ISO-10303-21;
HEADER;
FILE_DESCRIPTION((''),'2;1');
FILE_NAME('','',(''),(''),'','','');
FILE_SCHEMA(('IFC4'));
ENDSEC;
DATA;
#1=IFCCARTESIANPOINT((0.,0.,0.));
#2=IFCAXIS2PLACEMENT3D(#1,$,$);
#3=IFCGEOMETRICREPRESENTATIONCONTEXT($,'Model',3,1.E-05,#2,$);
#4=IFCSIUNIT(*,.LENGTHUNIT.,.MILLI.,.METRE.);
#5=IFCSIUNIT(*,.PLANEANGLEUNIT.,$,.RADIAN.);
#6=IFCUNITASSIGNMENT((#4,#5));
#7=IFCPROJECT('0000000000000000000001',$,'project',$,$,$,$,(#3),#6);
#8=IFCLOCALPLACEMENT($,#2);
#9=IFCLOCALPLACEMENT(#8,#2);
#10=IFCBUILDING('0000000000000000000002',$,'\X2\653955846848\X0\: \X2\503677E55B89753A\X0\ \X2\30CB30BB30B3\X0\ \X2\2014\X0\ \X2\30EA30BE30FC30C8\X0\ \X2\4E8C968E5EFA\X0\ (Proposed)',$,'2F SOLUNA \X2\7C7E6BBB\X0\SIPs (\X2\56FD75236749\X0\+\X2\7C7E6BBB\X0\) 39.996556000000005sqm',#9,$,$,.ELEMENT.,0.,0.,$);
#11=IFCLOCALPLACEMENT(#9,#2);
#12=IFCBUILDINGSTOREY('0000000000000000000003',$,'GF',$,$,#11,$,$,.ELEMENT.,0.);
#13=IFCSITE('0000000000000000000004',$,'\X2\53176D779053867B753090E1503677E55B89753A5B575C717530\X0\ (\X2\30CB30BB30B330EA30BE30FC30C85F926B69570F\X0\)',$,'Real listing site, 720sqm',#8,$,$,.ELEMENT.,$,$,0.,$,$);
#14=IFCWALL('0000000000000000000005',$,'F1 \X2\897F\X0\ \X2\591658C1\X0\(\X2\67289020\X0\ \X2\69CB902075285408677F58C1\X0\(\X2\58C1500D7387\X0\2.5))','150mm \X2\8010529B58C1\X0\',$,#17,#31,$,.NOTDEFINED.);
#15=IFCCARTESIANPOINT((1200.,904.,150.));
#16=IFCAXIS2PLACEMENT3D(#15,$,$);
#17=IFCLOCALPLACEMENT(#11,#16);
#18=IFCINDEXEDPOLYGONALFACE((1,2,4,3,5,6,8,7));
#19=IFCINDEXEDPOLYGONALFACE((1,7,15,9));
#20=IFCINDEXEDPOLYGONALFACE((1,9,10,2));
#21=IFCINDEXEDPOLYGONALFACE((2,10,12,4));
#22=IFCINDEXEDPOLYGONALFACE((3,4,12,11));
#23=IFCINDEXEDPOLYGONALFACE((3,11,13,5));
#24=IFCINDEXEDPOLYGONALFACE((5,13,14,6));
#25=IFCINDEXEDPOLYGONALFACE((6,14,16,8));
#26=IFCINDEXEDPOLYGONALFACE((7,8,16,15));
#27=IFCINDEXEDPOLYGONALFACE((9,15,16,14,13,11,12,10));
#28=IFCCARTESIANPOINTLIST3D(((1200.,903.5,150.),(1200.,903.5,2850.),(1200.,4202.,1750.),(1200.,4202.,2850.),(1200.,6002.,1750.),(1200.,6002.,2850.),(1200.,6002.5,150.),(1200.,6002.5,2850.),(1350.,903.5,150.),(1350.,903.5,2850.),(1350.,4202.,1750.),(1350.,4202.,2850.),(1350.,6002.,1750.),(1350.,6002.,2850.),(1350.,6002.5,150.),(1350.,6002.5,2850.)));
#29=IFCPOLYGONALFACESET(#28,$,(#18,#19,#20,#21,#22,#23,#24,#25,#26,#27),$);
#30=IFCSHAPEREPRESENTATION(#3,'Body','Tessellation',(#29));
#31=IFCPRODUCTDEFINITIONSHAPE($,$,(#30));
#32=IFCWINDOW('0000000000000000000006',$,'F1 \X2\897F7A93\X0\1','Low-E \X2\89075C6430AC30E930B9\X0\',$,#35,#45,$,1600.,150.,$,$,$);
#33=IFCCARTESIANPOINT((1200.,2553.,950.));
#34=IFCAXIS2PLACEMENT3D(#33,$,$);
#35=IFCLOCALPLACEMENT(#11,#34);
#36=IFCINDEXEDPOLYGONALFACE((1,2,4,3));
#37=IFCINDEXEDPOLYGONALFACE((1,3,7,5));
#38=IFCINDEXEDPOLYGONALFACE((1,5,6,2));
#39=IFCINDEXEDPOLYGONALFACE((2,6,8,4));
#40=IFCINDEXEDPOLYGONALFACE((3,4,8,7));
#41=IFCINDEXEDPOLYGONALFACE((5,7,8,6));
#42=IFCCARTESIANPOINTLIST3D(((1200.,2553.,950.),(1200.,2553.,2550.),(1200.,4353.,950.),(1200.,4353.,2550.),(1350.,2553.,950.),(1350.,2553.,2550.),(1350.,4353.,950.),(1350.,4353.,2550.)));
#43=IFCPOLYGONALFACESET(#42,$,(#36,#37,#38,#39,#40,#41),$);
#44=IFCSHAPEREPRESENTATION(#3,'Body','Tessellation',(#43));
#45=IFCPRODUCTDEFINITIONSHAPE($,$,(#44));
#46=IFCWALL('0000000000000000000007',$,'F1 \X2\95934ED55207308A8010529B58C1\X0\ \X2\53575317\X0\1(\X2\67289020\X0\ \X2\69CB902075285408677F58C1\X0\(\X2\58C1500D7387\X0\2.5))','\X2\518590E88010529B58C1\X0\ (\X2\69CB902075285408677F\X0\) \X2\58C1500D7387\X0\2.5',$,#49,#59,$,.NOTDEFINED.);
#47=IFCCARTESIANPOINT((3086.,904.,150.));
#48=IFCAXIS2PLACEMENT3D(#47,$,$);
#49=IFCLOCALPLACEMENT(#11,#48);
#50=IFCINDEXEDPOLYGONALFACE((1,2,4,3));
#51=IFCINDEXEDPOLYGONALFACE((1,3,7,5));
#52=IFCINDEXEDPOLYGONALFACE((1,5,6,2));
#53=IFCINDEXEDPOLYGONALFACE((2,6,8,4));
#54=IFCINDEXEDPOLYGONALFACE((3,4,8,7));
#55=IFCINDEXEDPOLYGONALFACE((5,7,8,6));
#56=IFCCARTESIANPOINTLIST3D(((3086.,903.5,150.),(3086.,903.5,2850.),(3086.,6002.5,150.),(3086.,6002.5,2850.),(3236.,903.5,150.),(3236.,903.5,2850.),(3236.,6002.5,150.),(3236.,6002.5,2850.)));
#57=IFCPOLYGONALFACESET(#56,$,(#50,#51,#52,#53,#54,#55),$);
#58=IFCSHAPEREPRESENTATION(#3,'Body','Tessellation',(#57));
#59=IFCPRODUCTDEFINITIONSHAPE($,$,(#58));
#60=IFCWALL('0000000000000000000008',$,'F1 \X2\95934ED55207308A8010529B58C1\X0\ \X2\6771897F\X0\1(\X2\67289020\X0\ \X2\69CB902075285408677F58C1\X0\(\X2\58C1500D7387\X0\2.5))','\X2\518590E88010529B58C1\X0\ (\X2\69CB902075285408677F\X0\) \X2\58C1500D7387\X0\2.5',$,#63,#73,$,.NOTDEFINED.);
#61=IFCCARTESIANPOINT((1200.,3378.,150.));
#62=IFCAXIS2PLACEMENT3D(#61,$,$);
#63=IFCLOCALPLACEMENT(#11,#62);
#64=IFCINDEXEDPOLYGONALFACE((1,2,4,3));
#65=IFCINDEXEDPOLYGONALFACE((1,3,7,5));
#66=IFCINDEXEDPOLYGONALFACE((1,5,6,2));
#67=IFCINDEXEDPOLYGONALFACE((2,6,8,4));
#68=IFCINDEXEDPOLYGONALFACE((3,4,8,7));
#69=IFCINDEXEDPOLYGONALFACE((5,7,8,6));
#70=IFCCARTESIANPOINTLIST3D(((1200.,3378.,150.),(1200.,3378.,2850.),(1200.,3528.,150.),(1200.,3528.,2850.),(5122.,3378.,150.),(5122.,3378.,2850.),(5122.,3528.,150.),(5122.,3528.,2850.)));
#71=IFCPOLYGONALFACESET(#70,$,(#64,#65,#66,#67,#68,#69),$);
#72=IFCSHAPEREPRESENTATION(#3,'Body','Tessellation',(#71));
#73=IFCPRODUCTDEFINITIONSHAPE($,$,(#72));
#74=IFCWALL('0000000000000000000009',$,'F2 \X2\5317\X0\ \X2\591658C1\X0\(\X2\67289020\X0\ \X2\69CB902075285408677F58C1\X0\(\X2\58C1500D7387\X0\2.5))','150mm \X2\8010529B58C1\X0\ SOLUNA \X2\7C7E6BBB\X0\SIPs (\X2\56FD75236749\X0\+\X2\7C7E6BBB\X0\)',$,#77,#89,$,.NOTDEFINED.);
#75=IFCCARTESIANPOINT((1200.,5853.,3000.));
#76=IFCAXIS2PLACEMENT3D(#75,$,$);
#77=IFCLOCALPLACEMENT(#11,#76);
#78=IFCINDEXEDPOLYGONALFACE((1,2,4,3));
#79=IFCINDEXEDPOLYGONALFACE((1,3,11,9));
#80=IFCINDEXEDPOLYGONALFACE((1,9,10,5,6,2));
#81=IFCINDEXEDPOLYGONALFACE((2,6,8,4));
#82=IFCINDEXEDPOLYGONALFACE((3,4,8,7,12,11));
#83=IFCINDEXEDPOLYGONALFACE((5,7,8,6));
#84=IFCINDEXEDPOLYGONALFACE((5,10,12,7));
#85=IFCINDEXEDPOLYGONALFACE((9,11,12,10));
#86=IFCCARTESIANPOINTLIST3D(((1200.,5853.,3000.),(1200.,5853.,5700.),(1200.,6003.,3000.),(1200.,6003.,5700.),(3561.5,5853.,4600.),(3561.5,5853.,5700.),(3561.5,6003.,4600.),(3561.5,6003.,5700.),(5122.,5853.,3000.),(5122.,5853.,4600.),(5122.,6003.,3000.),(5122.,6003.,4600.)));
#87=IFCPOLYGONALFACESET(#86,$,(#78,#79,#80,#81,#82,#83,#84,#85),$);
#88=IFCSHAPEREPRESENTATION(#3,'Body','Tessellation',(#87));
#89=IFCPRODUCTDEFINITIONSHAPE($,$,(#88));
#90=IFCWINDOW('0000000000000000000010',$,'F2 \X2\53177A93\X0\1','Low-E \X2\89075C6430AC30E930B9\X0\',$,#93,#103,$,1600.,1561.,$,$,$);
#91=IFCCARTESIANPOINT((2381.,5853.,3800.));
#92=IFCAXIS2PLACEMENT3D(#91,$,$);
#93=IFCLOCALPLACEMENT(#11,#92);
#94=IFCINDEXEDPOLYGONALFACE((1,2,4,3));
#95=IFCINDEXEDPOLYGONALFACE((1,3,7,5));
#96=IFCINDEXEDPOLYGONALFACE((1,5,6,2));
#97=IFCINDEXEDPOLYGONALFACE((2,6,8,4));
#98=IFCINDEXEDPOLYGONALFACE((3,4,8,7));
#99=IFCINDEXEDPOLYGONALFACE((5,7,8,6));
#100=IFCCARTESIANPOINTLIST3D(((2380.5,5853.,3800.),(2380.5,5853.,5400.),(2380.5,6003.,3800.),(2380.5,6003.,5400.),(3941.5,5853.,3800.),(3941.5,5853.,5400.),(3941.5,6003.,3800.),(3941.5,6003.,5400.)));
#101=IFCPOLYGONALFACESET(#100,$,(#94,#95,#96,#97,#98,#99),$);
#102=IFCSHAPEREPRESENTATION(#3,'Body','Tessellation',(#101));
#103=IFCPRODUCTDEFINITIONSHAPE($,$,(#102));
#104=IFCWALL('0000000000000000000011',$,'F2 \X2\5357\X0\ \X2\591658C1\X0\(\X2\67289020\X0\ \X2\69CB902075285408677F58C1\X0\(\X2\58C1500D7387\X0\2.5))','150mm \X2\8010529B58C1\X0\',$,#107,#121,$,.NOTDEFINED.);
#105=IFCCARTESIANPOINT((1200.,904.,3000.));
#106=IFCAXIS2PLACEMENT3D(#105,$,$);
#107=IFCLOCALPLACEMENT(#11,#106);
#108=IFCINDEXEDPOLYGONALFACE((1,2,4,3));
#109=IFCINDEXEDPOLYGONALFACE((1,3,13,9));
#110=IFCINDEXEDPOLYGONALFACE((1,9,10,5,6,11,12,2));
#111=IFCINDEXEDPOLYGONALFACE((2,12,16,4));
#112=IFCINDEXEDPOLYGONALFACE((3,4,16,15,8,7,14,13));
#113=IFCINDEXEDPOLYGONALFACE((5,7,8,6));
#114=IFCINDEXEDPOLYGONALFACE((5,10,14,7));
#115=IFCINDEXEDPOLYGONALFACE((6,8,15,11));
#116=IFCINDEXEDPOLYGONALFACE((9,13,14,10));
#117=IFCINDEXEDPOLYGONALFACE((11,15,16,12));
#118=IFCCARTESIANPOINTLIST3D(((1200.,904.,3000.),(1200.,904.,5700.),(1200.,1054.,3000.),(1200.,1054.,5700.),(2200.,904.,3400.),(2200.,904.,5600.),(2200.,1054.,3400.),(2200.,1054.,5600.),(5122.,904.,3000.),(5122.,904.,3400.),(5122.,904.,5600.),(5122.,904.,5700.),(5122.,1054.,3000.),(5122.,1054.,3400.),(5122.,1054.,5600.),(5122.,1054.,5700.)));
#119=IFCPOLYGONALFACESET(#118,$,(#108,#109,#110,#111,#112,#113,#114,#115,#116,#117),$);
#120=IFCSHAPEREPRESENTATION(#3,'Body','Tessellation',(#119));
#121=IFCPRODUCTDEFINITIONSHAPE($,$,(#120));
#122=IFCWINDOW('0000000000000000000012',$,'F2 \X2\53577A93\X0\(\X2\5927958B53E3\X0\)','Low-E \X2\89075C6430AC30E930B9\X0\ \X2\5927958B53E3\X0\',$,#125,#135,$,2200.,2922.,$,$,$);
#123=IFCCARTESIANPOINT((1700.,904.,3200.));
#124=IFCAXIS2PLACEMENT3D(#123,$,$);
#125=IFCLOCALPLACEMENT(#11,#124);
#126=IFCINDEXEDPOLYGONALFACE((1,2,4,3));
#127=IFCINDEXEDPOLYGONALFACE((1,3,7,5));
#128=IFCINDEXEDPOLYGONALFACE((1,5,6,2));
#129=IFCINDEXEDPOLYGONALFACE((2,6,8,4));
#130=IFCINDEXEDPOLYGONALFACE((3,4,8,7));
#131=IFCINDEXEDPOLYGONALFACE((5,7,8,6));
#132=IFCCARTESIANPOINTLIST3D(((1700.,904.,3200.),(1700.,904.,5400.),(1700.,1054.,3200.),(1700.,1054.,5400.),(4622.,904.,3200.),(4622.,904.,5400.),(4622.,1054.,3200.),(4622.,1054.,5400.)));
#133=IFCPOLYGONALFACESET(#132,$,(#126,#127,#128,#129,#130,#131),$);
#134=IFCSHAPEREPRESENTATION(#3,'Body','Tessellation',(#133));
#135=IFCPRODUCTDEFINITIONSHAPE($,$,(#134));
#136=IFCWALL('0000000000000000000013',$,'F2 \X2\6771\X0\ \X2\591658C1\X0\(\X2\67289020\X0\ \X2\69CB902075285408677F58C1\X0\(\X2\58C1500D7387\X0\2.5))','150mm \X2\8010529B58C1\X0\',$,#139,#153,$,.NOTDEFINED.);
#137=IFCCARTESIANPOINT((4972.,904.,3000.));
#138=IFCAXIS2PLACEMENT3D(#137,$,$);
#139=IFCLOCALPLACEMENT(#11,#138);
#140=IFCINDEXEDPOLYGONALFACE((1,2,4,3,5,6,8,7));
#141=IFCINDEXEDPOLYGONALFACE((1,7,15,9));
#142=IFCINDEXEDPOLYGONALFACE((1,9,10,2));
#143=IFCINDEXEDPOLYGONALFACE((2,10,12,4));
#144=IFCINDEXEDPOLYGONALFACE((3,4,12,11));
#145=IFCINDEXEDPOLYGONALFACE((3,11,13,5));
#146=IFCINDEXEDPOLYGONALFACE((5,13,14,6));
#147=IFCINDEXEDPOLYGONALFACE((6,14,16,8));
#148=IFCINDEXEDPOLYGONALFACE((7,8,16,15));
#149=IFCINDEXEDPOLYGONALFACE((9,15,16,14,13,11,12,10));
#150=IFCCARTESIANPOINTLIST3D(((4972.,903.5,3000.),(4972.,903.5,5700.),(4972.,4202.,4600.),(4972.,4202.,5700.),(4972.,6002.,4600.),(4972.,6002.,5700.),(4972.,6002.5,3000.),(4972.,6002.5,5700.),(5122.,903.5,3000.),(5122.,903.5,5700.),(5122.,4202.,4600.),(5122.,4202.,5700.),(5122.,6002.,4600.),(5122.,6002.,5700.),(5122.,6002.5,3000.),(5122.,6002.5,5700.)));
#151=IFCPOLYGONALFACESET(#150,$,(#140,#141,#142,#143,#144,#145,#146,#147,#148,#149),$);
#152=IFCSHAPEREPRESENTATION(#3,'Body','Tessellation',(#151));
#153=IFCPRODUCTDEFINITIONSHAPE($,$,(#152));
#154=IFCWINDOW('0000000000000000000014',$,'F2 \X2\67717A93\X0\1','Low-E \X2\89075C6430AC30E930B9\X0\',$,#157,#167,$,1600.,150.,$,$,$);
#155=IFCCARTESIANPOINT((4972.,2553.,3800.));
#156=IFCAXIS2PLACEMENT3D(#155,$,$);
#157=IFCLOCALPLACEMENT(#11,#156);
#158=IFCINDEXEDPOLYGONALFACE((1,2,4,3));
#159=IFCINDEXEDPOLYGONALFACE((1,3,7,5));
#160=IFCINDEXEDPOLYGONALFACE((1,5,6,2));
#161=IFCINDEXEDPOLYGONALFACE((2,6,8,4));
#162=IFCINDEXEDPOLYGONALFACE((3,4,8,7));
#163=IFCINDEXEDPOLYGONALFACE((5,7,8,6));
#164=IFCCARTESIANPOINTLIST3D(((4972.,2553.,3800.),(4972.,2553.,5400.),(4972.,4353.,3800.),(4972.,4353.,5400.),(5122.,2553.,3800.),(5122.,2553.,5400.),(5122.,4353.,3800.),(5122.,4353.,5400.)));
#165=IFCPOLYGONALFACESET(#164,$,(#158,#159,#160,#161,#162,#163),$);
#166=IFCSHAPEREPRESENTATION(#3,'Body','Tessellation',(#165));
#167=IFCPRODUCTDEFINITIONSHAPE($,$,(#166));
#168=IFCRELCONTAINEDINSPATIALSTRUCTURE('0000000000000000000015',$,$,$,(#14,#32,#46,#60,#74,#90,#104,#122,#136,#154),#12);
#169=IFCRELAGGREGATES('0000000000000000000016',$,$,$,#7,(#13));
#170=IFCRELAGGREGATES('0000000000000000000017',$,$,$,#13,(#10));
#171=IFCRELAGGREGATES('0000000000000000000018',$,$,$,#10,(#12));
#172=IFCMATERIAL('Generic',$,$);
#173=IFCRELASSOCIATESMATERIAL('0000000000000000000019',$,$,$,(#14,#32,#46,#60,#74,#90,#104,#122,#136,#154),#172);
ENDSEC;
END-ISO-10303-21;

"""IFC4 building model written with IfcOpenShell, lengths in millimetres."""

from ifc_helpers import new_model, si_unit, frame, frame_2d, origin, place, context, project, spatial, rectangle, extrude, material, element, fill, save


model = new_model("IFC4")

# Units and contexts
model_context = context("Model", 3, precision=1e-05, world=origin())
ifc_project = project(units=[si_unit("LENGTHUNIT", "METRE", prefix="MILLI"), si_unit("PLANEANGLEUNIT", "RADIAN")], contexts=[model_context])

# Site, building, storey
site_placement = place(None, origin())
site = spatial("IfcSite", under=ifc_project, at=site_placement, Name="北海道虻田郡倶知安町字山田 (ニセコリゾート徒歩圏)", ObjectType="Real listing site, 720sqm", CompositionType="ELEMENT", RefElevation=0.0)
building_placement = place(site_placement, origin())
building = spatial("IfcBuilding", under=site, at=building_placement, Name="改善案: 倶知安町 ニセコ — リゾート 二階建 (Proposed)", ObjectType="2F SOLUNA 籾殻SIPs (国産杉+籾殻) 39.996556000000005sqm", CompositionType="ELEMENT", ElevationOfRefHeight=0.0, ElevationOfTerrain=0.0)
storey_placement = place(building_placement, origin())
storey = spatial("IfcBuildingStorey", under=building, at=storey_placement, Name="GF", CompositionType="ELEMENT", Elevation=0.0)

# Shared definitions
ifc_material_1 = material(Name="Generic")

# Wall, opening, window
wall_1_placement = place(storey_placement, frame((1200.0, 904.0, 150.0)))
wall_1 = element("IfcWall", 1, at=wall_1_placement, inside=storey, material=ifc_material_1, Name="F1 西 外壁(木造 構造用合板壁(壁倍率2.5))", Description="150mm 耐力壁", PredefinedType="NOTDEFINED", context=model_context, shape_type="SweptSolid", body=[
    extrude(rectangle(XDim=150.0, YDim=5099.0, at=frame_2d((75.0, 2549.0))), frame((1200.0, 904.0, 150.0)), (0.0, 0.0, 1.0), 2700.0),
])
opening_1_placement = place(storey_placement, frame((1200.0, 2553.0, 950.0)))
opening_1 = element("IfcOpeningElement", 2, at=opening_1_placement, cuts=wall_1, PredefinedType="NOTDEFINED", context=model_context, shape_type="SweptSolid", body=[
    extrude(rectangle(XDim=150.0, YDim=1800.0, at=frame_2d((75.0, 900.0))), frame((1200.0, 2553.0, 950.0)), (0.0, 0.0, 1.0), 1600.0),
])
window_1_placement = place(storey_placement, frame((1200.0, 2553.0, 950.0)))
window_1 = element("IfcWindow", 3, at=window_1_placement, inside=storey, material=ifc_material_1, Name="F1 西窓1", Description="Low-E 複層ガラス", OverallHeight=1600.0, OverallWidth=150.0, context=model_context, shape_type="SweptSolid", body=[
    extrude(rectangle(XDim=150.0, YDim=1800.0, at=frame_2d((75.0, 900.0))), frame((1200.0, 2553.0, 950.0)), (0.0, 0.0, 1.0), 1600.0),
])
fill(opening_1, window_1)

# Walls
wall_2_placement = place(storey_placement, frame((3086.0, 904.0, 150.0)))
element("IfcWall", 4, at=wall_2_placement, inside=storey, material=ifc_material_1, Name="F1 間仕切り耐力壁 南北1(木造 構造用合板壁(壁倍率2.5))", Description="内部耐力壁 (構造用合板) 壁倍率2.5", PredefinedType="NOTDEFINED", context=model_context, shape_type="SweptSolid", body=[
    extrude(rectangle(XDim=150.0, YDim=5099.0, at=frame_2d((75.0, 2549.0))), frame((3086.0, 904.0, 150.0)), (0.0, 0.0, 1.0), 2700.0),
])
wall_3_placement = place(storey_placement, frame((1200.0, 3378.0, 150.0)))
element("IfcWall", 5, at=wall_3_placement, inside=storey, material=ifc_material_1, Name="F1 間仕切り耐力壁 東西1(木造 構造用合板壁(壁倍率2.5))", Description="内部耐力壁 (構造用合板) 壁倍率2.5", PredefinedType="NOTDEFINED", context=model_context, shape_type="SweptSolid", body=[
    extrude(rectangle(XDim=3922.0, YDim=150.0, at=frame_2d((1961.0, 75.0))), frame((1200.0, 3378.0, 150.0)), (0.0, 0.0, 1.0), 2700.0),
])

# Walls, openings, windows
wall_4_placement = place(storey_placement, frame((1200.0, 5853.0, 3000.0)))
wall_4 = element("IfcWall", 6, at=wall_4_placement, inside=storey, material=ifc_material_1, Name="F2 北 外壁(木造 構造用合板壁(壁倍率2.5))", Description="150mm 耐力壁 SOLUNA 籾殻SIPs (国産杉+籾殻)", PredefinedType="NOTDEFINED", context=model_context, shape_type="SweptSolid", body=[
    extrude(rectangle(XDim=3922.0, YDim=150.0, at=frame_2d((1961.0, 75.0))), frame((1200.0, 5853.0, 3000.0)), (0.0, 0.0, 1.0), 2700.0),
])
opening_2_placement = place(storey_placement, frame((2381.0, 5853.0, 3800.0)))
opening_2 = element("IfcOpeningElement", 7, at=opening_2_placement, cuts=wall_4, PredefinedType="NOTDEFINED", context=model_context, shape_type="SweptSolid", body=[
    extrude(rectangle(XDim=1561.0, YDim=150.0, at=frame_2d((780.0, 75.0))), frame((2381.0, 5853.0, 3800.0)), (0.0, 0.0, 1.0), 1600.0),
])
window_2_placement = place(storey_placement, frame((2381.0, 5853.0, 3800.0)))
window_2 = element("IfcWindow", 8, at=window_2_placement, inside=storey, material=ifc_material_1, Name="F2 北窓1", Description="Low-E 複層ガラス", OverallHeight=1600.0, OverallWidth=1561.0, context=model_context, shape_type="SweptSolid", body=[
    extrude(rectangle(XDim=1561.0, YDim=150.0, at=frame_2d((780.0, 75.0))), frame((2381.0, 5853.0, 3800.0)), (0.0, 0.0, 1.0), 1600.0),
])
fill(opening_2, window_2)
wall_5_placement = place(storey_placement, frame((1200.0, 904.0, 3000.0)))
wall_5 = element("IfcWall", 9, at=wall_5_placement, inside=storey, material=ifc_material_1, Name="F2 南 外壁(木造 構造用合板壁(壁倍率2.5))", Description="150mm 耐力壁", PredefinedType="NOTDEFINED", context=model_context, shape_type="SweptSolid", body=[
    extrude(rectangle(XDim=3922.0, YDim=150.0, at=frame_2d((1961.0, 75.0))), frame((1200.0, 904.0, 3000.0)), (0.0, 0.0, 1.0), 2700.0),
])
opening_3_placement = place(storey_placement, frame((1700.0, 904.0, 3200.0)))
opening_3 = element("IfcOpeningElement", 10, at=opening_3_placement, cuts=wall_5, PredefinedType="NOTDEFINED", context=model_context, shape_type="SweptSolid", body=[
    extrude(rectangle(XDim=2922.0, YDim=150.0, at=frame_2d((1461.0, 75.0))), frame((1700.0, 904.0, 3200.0)), (0.0, 0.0, 1.0), 2200.0),
])
window_3_placement = place(storey_placement, frame((1700.0, 904.0, 3200.0)))
window_3 = element("IfcWindow", 11, at=window_3_placement, inside=storey, material=ifc_material_1, Name="F2 南窓(大開口)", Description="Low-E 複層ガラス 大開口", OverallHeight=2200.0, OverallWidth=2922.0, context=model_context, shape_type="SweptSolid", body=[
    extrude(rectangle(XDim=2922.0, YDim=150.0, at=frame_2d((1461.0, 75.0))), frame((1700.0, 904.0, 3200.0)), (0.0, 0.0, 1.0), 2200.0),
])
fill(opening_3, window_3)
wall_6_placement = place(storey_placement, frame((4972.0, 904.0, 3000.0)))
wall_6 = element("IfcWall", 12, at=wall_6_placement, inside=storey, material=ifc_material_1, Name="F2 東 外壁(木造 構造用合板壁(壁倍率2.5))", Description="150mm 耐力壁", PredefinedType="NOTDEFINED", context=model_context, shape_type="SweptSolid", body=[
    extrude(rectangle(XDim=150.0, YDim=5099.0, at=frame_2d((75.0, 2549.0))), frame((4972.0, 904.0, 3000.0)), (0.0, 0.0, 1.0), 2700.0),
])
opening_4_placement = place(storey_placement, frame((4972.0, 2553.0, 3800.0)))
opening_4 = element("IfcOpeningElement", 13, at=opening_4_placement, cuts=wall_6, PredefinedType="NOTDEFINED", context=model_context, shape_type="SweptSolid", body=[
    extrude(rectangle(XDim=150.0, YDim=1800.0, at=frame_2d((75.0, 900.0))), frame((4972.0, 2553.0, 3800.0)), (0.0, 0.0, 1.0), 1600.0),
])
window_4_placement = place(storey_placement, frame((4972.0, 2553.0, 3800.0)))
window_4 = element("IfcWindow", 14, at=window_4_placement, inside=storey, material=ifc_material_1, Name="F2 東窓1", Description="Low-E 複層ガラス", OverallHeight=1600.0, OverallWidth=150.0, context=model_context, shape_type="SweptSolid", body=[
    extrude(rectangle(XDim=150.0, YDim=1800.0, at=frame_2d((75.0, 900.0))), frame((4972.0, 2553.0, 3800.0)), (0.0, 0.0, 1.0), 1600.0),
])
fill(opening_4, window_4)

save(model, "model.ifc")
